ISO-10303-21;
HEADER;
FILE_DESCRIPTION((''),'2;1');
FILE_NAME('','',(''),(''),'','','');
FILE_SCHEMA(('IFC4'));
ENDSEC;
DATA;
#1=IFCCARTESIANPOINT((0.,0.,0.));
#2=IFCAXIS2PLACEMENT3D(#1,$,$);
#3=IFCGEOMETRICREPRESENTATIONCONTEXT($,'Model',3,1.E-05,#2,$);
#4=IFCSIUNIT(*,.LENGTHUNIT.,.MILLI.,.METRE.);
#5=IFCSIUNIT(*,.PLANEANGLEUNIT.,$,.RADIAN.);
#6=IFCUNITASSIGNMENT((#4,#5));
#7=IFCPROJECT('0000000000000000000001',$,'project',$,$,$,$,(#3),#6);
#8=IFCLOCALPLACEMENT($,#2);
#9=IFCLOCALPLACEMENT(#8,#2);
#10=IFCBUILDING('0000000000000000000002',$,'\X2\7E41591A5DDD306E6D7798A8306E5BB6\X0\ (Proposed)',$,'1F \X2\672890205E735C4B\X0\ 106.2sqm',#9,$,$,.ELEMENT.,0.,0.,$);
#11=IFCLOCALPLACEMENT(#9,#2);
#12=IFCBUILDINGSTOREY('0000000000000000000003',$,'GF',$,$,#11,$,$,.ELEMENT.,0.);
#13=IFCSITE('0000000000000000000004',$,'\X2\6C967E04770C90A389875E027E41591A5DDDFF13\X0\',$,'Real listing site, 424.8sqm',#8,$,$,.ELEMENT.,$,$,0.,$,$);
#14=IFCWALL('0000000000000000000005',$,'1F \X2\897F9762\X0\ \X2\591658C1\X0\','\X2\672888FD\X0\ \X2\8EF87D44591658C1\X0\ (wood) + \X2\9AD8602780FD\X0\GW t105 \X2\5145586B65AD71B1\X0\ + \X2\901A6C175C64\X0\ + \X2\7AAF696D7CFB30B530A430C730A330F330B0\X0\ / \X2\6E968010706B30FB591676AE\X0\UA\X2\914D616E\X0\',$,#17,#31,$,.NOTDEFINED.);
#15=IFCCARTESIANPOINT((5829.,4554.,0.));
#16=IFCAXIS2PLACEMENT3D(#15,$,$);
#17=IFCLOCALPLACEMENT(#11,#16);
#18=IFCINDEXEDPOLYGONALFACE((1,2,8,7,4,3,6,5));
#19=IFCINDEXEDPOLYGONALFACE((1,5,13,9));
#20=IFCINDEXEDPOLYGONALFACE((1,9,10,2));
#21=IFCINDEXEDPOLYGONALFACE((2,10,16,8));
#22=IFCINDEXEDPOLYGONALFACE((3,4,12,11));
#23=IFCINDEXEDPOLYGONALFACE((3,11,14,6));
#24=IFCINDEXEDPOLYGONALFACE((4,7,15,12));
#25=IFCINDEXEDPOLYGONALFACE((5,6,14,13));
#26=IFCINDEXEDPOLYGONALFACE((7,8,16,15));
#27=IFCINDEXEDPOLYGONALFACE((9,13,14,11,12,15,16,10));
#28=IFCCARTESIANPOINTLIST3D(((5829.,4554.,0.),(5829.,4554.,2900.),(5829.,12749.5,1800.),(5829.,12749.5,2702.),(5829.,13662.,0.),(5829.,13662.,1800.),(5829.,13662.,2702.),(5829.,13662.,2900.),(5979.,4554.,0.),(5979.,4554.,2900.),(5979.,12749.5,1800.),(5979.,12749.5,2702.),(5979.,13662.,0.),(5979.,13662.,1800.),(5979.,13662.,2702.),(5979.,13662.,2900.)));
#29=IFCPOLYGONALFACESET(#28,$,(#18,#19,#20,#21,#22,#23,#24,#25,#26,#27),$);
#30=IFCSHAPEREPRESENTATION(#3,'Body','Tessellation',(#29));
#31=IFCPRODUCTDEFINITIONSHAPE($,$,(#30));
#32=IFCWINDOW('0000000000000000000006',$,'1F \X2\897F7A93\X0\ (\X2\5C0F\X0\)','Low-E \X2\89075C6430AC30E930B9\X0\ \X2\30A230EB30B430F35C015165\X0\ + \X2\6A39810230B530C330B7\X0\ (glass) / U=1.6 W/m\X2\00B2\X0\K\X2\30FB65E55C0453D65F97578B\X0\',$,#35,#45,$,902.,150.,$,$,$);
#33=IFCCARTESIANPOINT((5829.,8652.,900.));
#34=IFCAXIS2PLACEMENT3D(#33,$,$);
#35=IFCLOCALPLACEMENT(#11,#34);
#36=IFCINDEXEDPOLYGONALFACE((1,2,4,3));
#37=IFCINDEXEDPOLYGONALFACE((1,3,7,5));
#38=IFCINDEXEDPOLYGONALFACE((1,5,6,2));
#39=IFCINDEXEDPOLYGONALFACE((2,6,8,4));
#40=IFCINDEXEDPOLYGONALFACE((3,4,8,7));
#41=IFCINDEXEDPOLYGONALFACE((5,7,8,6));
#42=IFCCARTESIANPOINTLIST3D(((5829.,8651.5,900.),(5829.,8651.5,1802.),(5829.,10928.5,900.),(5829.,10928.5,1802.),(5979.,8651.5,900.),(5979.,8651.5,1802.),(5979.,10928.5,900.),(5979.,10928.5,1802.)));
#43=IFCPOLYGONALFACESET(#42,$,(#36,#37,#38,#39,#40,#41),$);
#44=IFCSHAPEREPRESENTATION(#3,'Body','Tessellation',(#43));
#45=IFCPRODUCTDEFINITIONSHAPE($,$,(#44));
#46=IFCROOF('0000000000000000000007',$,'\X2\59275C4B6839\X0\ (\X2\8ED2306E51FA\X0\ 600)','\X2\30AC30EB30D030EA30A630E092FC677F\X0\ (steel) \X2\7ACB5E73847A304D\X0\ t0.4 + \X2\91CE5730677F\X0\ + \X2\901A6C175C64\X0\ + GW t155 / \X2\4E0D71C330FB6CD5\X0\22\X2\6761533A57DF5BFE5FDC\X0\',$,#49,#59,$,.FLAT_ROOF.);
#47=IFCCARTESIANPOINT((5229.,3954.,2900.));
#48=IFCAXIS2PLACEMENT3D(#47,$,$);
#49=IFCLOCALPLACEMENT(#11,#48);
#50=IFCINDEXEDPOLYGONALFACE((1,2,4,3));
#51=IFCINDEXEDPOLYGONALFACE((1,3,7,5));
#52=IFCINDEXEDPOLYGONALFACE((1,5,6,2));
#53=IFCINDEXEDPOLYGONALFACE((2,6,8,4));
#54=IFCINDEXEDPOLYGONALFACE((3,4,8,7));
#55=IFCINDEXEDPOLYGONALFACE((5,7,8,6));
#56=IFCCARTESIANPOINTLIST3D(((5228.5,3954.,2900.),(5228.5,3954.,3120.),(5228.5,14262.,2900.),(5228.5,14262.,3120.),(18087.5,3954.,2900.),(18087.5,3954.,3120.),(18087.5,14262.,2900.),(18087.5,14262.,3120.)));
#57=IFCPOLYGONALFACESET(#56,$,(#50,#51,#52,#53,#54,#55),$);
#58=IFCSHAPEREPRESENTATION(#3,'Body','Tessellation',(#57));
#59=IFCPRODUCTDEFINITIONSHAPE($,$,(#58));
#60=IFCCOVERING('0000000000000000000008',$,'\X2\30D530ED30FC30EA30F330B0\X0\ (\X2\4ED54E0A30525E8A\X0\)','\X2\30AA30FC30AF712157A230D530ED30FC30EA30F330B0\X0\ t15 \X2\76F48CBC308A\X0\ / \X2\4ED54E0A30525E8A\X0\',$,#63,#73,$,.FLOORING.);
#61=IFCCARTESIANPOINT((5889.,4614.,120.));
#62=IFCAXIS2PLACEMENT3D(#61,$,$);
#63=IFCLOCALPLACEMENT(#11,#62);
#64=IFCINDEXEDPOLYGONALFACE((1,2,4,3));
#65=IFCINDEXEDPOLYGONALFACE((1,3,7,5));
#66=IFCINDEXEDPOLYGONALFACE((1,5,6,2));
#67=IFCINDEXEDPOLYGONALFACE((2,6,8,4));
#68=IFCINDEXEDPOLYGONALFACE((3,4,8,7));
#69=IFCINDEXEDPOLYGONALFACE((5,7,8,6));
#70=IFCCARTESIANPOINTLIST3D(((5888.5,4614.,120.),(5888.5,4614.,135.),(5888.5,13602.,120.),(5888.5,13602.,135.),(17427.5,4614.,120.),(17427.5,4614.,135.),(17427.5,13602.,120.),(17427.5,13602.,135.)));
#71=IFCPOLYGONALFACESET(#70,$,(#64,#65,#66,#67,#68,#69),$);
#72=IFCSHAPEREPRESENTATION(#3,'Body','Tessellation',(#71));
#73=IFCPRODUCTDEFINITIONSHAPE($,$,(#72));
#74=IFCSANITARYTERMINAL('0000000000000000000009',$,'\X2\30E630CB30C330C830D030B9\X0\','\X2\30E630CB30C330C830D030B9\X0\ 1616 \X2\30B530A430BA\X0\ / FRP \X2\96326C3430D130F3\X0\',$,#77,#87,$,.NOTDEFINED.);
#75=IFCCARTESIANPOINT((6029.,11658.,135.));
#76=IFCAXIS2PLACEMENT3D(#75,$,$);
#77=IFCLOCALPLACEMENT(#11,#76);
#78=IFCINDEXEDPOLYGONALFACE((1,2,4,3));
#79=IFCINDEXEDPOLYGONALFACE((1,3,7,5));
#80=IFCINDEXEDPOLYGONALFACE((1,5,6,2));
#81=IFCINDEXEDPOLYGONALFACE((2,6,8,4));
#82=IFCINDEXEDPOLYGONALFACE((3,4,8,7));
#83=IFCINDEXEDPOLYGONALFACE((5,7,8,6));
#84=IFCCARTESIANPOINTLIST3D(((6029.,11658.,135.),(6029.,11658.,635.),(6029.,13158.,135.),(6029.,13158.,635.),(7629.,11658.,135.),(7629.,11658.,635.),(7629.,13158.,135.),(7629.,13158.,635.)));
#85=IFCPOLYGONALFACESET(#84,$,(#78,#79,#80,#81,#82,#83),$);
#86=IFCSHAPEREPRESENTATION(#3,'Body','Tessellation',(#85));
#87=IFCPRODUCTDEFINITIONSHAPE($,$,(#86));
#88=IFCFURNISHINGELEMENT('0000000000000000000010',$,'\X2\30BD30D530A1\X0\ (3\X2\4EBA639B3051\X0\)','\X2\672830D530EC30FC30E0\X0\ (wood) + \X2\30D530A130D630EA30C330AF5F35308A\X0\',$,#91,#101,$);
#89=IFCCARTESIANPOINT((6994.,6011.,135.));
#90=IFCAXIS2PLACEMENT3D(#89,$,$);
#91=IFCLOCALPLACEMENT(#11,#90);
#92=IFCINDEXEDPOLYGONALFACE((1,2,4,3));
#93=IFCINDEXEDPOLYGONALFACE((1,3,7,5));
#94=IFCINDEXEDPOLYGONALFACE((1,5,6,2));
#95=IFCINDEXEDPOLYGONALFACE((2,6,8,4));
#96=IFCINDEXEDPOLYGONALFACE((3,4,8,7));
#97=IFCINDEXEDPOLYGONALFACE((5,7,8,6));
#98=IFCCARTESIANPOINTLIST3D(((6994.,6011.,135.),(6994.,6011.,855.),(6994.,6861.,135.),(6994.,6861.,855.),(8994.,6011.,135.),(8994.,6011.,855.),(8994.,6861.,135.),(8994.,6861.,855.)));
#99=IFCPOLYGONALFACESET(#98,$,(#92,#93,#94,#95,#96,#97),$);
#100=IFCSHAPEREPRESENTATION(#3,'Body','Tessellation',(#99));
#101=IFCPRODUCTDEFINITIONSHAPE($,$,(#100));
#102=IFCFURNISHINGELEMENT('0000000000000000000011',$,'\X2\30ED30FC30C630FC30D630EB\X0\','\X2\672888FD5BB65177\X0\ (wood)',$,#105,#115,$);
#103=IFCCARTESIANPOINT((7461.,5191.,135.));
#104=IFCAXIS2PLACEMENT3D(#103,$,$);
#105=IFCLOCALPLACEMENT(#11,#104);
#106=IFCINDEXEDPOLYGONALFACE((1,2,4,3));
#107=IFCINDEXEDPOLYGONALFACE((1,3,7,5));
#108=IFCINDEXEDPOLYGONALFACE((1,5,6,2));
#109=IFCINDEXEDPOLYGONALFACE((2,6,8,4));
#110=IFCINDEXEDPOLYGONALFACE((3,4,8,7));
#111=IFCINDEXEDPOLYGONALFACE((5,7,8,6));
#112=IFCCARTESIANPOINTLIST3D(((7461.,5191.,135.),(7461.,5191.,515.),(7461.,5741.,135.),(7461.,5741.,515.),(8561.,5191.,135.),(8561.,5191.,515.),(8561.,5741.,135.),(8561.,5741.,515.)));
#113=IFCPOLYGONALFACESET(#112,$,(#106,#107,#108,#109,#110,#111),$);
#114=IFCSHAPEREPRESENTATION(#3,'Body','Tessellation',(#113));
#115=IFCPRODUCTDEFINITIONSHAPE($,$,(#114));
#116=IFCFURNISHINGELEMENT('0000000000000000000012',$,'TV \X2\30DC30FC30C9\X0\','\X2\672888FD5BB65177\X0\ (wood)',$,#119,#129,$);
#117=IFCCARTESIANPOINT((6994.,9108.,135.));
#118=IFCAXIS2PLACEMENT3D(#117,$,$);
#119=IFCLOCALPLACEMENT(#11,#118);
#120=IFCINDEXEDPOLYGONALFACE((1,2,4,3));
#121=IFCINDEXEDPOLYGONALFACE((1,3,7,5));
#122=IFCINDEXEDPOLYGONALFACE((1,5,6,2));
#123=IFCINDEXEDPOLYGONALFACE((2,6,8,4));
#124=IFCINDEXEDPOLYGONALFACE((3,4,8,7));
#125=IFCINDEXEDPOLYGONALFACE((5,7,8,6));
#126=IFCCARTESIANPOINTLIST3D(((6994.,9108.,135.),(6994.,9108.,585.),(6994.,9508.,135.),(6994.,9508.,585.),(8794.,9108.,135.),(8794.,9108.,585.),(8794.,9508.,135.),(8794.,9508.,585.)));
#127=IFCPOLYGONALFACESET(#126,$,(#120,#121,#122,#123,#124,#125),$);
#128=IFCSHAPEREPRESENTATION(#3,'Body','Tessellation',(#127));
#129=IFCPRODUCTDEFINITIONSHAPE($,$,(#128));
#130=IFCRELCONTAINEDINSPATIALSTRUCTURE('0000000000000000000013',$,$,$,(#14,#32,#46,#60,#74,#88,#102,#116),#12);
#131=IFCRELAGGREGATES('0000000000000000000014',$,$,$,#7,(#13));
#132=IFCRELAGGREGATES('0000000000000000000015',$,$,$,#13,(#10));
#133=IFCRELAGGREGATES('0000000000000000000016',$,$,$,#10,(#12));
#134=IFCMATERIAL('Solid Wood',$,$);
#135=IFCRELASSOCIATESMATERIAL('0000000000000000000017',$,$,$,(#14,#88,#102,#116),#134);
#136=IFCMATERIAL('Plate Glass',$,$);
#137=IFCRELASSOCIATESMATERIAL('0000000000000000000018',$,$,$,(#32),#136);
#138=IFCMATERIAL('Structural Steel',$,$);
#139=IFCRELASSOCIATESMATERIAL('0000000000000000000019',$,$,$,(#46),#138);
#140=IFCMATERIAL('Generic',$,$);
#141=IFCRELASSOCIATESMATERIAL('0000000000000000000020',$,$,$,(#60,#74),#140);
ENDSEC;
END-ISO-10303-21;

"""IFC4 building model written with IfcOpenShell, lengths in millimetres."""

from ifc_helpers import new_model, si_unit, frame, frame_2d, origin, place, context, project, spatial, rectangle, extrude, material, element, fill, save


model = new_model("IFC4")

# Units and contexts
model_context = context("Model", 3, precision=1e-05, world=origin())
ifc_project = project(units=[si_unit("LENGTHUNIT", "METRE", prefix="MILLI"), si_unit("PLANEANGLEUNIT", "RADIAN")], contexts=[model_context])

# Site, building, storey
site_placement = place(None, origin())
site = spatial("IfcSite", under=ifc_project, at=site_placement, Name="沖縄県那覇市繁多川３", ObjectType="Real listing site, 424.8sqm", CompositionType="ELEMENT", RefElevation=0.0)
building_placement = place(site_placement, origin())
building = spatial("IfcBuilding", under=site, at=building_placement, Name="繁多川の海風の家 (Proposed)", ObjectType="1F 木造平屋 106.2sqm", CompositionType="ELEMENT", ElevationOfRefHeight=0.0, ElevationOfTerrain=0.0)
storey_placement = place(building_placement, origin())
storey = spatial("IfcBuildingStorey", under=building, at=storey_placement, Name="GF", CompositionType="ELEMENT", Elevation=0.0)

# Shared definitions
ifc_material_1 = material(Name="Solid Wood")

# Shared definitions
ifc_material_2 = material(Name="Plate Glass")

# Wall, opening, window
wall_1_placement = place(storey_placement, frame((5829.0, 4554.0, 0.0)))
wall_1 = element("IfcWall", 1, at=wall_1_placement, inside=storey, material=ifc_material_1, Name="1F 西面 外壁", Description="木製 軸組外壁 (wood) + 高性能GW t105 充填断熱 + 通気層 + 窯業系サイディング / 準耐火・外皮UA配慮", PredefinedType="NOTDEFINED", context=model_context, shape_type="SweptSolid", body=[
    extrude(rectangle(XDim=150.0, YDim=9108.0, at=frame_2d((75.0, 4554.0))), frame((5829.0, 4554.0, 0.0)), (0.0, 0.0, 1.0), 2900.0),
])
opening_1_placement = place(storey_placement, frame((5829.0, 8652.0, 900.0)))
opening_1 = element("IfcOpeningElement", 2, at=opening_1_placement, cuts=wall_1, PredefinedType="NOTDEFINED", context=model_context, shape_type="SweptSolid", body=[
    extrude(rectangle(XDim=150.0, YDim=2277.0, at=frame_2d((75.0, 1138.0))), frame((5829.0, 8652.0, 900.0)), (0.0, 0.0, 1.0), 902.0),
])
window_1_placement = place(storey_placement, frame((5829.0, 8652.0, 900.0)))
window_1 = element("IfcWindow", 3, at=window_1_placement, inside=storey, material=ifc_material_2, Name="1F 西窓 (小)", Description="Low-E 複層ガラス アルゴン封入 + 樹脂サッシ (glass) / U=1.6 W/m²K・日射取得型", OverallHeight=902.0, OverallWidth=150.0, context=model_context, shape_type="SweptSolid", body=[
    extrude(rectangle(XDim=150.0, YDim=2277.0, at=frame_2d((75.0, 1138.0))), frame((5829.0, 8652.0, 900.0)), (0.0, 0.0, 1.0), 902.0),
])
fill(opening_1, window_1)

# Roof
ifc_material_3 = material(Name="Structural Steel")
roof_placement = place(storey_placement, frame((5229.0, 3954.0, 2900.0)))
element("IfcRoof", 4, at=roof_placement, inside=storey, material=ifc_material_3, Name="大屋根 (軒の出 600)", Description="ガルバリウム鋼板 (steel) 立平葺き t0.4 + 野地板 + 通気層 + GW t155 / 不燃・法22条区域対応", PredefinedType="FLAT_ROOF", context=model_context, shape_type="SweptSolid", body=[
    extrude(rectangle(XDim=12859.0, YDim=10308.0, at=frame_2d((6429.0, 5154.0))), frame((5229.0, 3954.0, 2900.0)), (0.0, 0.0, 1.0), 220.0),
])

# Covering
ifc_material_4 = material(Name="Generic")
covering_placement = place(storey_placement, frame((5889.0, 4614.0, 120.0)))
element("IfcCovering", 5, at=covering_placement, inside=storey, material=ifc_material_4, Name="フローリング (仕上げ床)", Description="オーク無垢フローリング t15 直貼り / 仕上げ床", PredefinedType="FLOORING", context=model_context, shape_type="SweptSolid", body=[
    extrude(rectangle(XDim=11539.0, YDim=8988.0, at=frame_2d((5769.0, 4494.0))), frame((5889.0, 4614.0, 120.0)), (0.0, 0.0, 1.0), 15.0),
])

# Sanitary terminal
sanitary_terminal_placement = place(storey_placement, frame((6029.0, 11658.0, 135.0)))
element("IfcSanitaryTerminal", 6, at=sanitary_terminal_placement, inside=storey, material=ifc_material_4, Name="ユニットバス", Description="ユニットバス 1616 サイズ / FRP 防水パン", PredefinedType="NOTDEFINED", context=model_context, shape_type="SweptSolid", body=[
    extrude(rectangle(XDim=1600.0, YDim=1500.0, at=frame_2d((800.0, 750.0))), frame((6029.0, 11658.0, 135.0)), (0.0, 0.0, 1.0), 500.0),
])

# Furnishing elements
furnishing_1_placement = place(storey_placement, frame((6994.0, 6011.0, 135.0)))
element("IfcFurnishingElement", 7, at=furnishing_1_placement, inside=storey, material=ifc_material_1, Name="ソファ (3人掛け)", Description="木フレーム (wood) + ファブリック張り", context=model_context, shape_type="SweptSolid", body=[
    extrude(rectangle(XDim=2000.0, YDim=850.0, at=frame_2d((1000.0, 425.0))), frame((6994.0, 6011.0, 135.0)), (0.0, 0.0, 1.0), 720.0),
])
furnishing_2_placement = place(storey_placement, frame((7461.0, 5191.0, 135.0)))
element("IfcFurnishingElement", 8, at=furnishing_2_placement, inside=storey, material=ifc_material_1, Name="ローテーブル", Description="木製家具 (wood)", context=model_context, shape_type="SweptSolid", body=[
    extrude(rectangle(XDim=1100.0, YDim=550.0, at=frame_2d((550.0, 275.0))), frame((7461.0, 5191.0, 135.0)), (0.0, 0.0, 1.0), 380.0),
])
furnishing_3_placement = place(storey_placement, frame((6994.0, 9108.0, 135.0)))
element("IfcFurnishingElement", 9, at=furnishing_3_placement, inside=storey, material=ifc_material_1, Name="TV ボード", Description="木製家具 (wood)", context=model_context, shape_type="SweptSolid", body=[
    extrude(rectangle(XDim=1800.0, YDim=400.0, at=frame_2d((900.0, 200.0))), frame((6994.0, 9108.0, 135.0)), (0.0, 0.0, 1.0), 450.0),
])

save(model, "model.ifc")
